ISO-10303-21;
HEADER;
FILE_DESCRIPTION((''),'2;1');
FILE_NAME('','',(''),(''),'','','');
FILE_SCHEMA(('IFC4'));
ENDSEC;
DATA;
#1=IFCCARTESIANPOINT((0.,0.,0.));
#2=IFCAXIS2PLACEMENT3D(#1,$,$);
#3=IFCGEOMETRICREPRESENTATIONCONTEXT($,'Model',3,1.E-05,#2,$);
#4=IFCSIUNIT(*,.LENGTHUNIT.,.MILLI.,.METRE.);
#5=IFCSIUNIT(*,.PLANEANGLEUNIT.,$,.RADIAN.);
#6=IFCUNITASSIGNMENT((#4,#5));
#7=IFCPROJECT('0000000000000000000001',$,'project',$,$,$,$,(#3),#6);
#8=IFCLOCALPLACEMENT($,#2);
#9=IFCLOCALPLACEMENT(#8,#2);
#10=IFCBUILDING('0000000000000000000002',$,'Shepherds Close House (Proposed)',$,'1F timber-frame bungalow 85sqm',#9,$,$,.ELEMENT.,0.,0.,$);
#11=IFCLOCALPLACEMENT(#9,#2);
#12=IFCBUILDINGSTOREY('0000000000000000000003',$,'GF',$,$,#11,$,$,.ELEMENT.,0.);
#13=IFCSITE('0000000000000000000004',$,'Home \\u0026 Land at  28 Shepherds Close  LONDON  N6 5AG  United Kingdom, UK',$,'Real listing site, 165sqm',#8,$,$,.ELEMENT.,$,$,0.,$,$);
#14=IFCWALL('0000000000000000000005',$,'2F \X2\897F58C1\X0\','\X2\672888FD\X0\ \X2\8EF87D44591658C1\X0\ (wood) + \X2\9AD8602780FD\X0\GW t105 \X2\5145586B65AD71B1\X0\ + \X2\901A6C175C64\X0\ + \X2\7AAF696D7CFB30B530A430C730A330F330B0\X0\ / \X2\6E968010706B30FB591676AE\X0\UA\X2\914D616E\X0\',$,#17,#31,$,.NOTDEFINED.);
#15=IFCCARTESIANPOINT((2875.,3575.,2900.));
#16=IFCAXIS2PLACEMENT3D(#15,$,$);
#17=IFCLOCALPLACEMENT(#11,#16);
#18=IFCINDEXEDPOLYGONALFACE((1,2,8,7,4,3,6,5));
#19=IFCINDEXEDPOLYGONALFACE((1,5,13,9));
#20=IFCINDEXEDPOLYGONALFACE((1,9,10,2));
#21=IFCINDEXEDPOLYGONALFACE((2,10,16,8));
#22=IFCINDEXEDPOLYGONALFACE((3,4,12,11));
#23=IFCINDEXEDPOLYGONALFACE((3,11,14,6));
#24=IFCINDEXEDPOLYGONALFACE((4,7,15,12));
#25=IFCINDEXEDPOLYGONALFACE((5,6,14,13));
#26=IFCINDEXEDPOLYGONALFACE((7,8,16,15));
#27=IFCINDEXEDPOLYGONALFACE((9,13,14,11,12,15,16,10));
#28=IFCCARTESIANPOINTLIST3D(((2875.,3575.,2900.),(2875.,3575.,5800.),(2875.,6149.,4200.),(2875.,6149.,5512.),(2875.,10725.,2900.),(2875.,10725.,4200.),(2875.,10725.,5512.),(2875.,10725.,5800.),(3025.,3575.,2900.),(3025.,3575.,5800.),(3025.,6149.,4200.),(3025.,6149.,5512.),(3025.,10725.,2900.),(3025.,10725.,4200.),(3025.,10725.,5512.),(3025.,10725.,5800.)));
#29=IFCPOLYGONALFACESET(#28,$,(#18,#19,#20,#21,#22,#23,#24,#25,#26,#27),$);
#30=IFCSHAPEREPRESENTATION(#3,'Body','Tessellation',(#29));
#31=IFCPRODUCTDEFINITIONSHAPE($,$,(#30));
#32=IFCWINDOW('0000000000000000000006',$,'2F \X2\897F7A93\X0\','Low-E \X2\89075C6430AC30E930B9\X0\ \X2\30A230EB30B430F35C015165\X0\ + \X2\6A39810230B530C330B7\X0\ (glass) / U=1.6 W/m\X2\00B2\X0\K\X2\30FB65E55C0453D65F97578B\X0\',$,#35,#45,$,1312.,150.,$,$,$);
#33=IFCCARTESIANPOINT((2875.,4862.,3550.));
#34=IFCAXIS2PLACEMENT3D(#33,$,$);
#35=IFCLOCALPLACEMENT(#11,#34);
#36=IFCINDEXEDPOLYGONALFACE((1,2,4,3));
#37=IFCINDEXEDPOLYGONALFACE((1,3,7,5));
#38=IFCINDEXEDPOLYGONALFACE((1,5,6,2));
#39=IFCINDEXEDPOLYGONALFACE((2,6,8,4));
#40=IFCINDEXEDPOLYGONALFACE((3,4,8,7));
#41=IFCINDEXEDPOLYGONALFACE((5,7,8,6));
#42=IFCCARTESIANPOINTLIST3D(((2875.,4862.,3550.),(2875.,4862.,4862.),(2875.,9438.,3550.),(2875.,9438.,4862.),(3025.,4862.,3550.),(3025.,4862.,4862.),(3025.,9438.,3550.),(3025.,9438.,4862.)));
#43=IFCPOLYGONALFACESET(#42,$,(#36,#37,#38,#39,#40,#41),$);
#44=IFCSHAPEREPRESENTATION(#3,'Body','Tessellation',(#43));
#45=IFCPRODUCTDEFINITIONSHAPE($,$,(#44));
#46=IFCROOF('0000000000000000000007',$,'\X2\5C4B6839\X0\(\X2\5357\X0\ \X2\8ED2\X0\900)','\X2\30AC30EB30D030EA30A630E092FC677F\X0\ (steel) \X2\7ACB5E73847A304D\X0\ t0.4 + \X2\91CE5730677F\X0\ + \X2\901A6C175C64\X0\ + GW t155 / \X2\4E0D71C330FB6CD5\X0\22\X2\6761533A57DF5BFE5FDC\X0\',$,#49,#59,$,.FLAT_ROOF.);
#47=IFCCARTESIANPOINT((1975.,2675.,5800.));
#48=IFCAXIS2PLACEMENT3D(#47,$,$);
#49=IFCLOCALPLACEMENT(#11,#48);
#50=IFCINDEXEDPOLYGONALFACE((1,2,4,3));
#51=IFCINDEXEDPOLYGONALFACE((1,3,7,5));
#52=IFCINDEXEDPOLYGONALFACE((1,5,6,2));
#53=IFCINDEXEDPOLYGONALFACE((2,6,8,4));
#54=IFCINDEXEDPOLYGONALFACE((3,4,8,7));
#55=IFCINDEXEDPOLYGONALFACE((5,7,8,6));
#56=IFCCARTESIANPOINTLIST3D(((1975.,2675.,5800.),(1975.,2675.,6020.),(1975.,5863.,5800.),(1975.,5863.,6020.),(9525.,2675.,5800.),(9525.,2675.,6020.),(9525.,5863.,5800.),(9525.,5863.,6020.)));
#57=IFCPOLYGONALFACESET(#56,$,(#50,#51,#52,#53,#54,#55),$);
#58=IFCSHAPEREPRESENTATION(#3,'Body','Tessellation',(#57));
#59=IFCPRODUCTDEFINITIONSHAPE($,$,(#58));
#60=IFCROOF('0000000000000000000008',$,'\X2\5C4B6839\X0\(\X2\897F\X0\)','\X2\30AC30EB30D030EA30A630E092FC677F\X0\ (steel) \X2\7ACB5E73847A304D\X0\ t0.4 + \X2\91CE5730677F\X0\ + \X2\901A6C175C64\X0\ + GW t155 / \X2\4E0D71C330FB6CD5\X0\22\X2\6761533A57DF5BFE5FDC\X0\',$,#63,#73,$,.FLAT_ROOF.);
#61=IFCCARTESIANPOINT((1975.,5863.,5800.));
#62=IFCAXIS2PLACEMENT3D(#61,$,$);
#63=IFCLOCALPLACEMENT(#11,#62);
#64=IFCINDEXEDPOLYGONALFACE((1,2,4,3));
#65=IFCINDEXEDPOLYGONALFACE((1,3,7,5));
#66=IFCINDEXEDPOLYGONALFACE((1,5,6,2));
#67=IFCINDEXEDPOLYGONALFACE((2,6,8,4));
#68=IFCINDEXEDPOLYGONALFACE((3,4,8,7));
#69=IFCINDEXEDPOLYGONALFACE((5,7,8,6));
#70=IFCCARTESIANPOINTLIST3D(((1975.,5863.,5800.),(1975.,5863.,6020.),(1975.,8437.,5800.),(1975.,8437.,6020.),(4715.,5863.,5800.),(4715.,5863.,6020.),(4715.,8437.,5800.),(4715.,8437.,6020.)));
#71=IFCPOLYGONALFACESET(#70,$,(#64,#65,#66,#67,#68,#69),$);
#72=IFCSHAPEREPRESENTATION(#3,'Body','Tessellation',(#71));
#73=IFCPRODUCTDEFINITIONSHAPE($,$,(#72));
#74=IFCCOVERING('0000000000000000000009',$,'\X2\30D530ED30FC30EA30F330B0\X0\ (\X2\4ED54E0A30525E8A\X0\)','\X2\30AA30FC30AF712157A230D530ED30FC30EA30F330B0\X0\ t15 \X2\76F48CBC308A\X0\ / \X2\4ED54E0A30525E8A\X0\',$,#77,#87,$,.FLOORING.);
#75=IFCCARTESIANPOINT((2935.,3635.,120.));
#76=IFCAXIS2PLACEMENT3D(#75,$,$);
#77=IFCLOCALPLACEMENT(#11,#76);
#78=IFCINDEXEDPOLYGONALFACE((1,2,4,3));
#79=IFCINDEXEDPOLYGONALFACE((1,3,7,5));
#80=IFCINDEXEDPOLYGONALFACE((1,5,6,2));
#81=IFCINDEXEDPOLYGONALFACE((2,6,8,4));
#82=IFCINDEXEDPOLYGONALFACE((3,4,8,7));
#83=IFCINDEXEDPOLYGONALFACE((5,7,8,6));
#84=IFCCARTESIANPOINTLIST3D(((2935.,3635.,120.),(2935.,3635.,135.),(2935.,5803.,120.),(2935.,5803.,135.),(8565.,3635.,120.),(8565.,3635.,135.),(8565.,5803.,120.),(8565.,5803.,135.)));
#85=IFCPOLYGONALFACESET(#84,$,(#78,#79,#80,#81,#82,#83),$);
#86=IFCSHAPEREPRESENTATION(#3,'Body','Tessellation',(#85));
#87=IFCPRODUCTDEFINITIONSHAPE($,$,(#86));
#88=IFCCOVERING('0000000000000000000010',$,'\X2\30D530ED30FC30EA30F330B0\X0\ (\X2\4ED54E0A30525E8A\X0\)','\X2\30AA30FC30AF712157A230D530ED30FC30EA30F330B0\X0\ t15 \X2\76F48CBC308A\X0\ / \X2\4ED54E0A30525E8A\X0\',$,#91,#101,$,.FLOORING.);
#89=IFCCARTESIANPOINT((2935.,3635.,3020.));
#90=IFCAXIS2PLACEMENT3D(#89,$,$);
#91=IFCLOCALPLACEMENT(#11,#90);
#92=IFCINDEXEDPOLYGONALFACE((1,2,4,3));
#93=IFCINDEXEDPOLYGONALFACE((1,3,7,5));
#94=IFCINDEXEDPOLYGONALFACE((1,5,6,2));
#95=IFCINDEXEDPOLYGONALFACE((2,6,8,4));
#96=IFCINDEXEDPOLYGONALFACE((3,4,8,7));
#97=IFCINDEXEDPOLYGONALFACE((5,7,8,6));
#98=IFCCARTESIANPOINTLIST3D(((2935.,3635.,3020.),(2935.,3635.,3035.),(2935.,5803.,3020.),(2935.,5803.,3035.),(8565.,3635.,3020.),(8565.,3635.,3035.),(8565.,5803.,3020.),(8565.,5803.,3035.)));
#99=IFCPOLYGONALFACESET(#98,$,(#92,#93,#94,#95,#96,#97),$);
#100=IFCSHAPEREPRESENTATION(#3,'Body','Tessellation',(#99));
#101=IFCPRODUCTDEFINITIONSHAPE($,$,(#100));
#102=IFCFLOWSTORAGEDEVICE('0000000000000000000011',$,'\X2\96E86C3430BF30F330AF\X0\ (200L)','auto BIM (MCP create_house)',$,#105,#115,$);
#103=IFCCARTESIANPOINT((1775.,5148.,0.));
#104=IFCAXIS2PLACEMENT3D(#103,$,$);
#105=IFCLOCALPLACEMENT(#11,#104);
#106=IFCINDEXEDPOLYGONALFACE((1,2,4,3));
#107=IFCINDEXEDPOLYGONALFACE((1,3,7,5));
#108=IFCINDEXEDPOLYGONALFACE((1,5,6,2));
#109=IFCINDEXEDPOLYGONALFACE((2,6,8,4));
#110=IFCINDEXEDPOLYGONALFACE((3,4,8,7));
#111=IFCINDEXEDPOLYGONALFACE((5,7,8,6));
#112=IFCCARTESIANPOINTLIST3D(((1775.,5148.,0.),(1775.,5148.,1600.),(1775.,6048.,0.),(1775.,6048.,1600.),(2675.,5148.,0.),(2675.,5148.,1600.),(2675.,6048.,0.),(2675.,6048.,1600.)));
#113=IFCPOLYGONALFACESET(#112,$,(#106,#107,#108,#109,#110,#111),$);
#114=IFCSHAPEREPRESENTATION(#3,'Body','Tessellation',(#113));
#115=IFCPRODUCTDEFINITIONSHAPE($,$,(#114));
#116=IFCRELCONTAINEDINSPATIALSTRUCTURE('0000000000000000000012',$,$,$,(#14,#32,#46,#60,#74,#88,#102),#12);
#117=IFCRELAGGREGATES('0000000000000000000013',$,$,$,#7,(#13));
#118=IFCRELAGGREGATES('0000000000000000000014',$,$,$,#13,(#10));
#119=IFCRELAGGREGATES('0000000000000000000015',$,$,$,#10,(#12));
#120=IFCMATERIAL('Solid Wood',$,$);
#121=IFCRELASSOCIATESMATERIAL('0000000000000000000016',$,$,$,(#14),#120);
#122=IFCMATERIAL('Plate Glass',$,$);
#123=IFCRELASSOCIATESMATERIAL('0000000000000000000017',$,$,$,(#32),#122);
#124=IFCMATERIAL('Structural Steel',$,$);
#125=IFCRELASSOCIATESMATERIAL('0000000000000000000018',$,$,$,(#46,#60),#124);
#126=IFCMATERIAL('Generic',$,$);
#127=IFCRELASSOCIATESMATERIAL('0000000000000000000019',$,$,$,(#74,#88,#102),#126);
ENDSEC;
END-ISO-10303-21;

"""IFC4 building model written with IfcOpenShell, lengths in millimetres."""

from ifc_helpers import new_model, si_unit, frame, frame_2d, origin, place, context, project, spatial, rectangle, extrude, material, element, fill, save


model = new_model("IFC4")

# Units and contexts
model_context = context("Model", 3, precision=1e-05, world=origin())
ifc_project = project(units=[si_unit("LENGTHUNIT", "METRE", prefix="MILLI"), si_unit("PLANEANGLEUNIT", "RADIAN")], contexts=[model_context])

# Site, building, storey
site_placement = place(None, origin())
site = spatial("IfcSite", under=ifc_project, at=site_placement, Name="Home \\u0026 Land at  28 Shepherds Close  LONDON  N6 5AG  United Kingdom, UK", ObjectType="Real listing site, 165sqm", CompositionType="ELEMENT", RefElevation=0.0)
building_placement = place(site_placement, origin())
building = spatial("IfcBuilding", under=site, at=building_placement, Name="Shepherds Close House (Proposed)", ObjectType="1F timber-frame bungalow 85sqm", CompositionType="ELEMENT", ElevationOfRefHeight=0.0, ElevationOfTerrain=0.0)
storey_placement = place(building_placement, origin())
storey = spatial("IfcBuildingStorey", under=building, at=storey_placement, Name="GF", CompositionType="ELEMENT", Elevation=0.0)

# Shared definitions
ifc_material_1 = material(Name="Solid Wood")
ifc_material_2 = material(Name="Generic")

# Shared definitions
ifc_material_3 = material(Name="Plate Glass")

# Wall, opening, window
wall_1_placement = place(storey_placement, frame((2875.0, 3575.0, 2900.0)))
wall_1 = element("IfcWall", 1, at=wall_1_placement, inside=storey, material=ifc_material_1, Name="2F 西壁", Description="木製 軸組外壁 (wood) + 高性能GW t105 充填断熱 + 通気層 + 窯業系サイディング / 準耐火・外皮UA配慮", PredefinedType="NOTDEFINED", context=model_context, shape_type="SweptSolid", body=[
    extrude(rectangle(XDim=150.0, YDim=7150.0, at=frame_2d((75.0, 3575.0))), frame((2875.0, 3575.0, 2900.0)), (0.0, 0.0, 1.0), 2900.0),
])
opening_1_placement = place(storey_placement, frame((2875.0, 4862.0, 3550.0)))
opening_1 = element("IfcOpeningElement", 2, at=opening_1_placement, cuts=wall_1, PredefinedType="NOTDEFINED", context=model_context, shape_type="SweptSolid", body=[
    extrude(rectangle(XDim=150.0, YDim=4576.0, at=frame_2d((75.0, 2288.0))), frame((2875.0, 4862.0, 3550.0)), (0.0, 0.0, 1.0), 1312.0),
])
window_1_placement = place(storey_placement, frame((2875.0, 4862.0, 3550.0)))
window_1 = element("IfcWindow", 3, at=window_1_placement, inside=storey, material=ifc_material_3, Name="2F 西窓", Description="Low-E 複層ガラス アルゴン封入 + 樹脂サッシ (glass) / U=1.6 W/m²K・日射取得型", OverallHeight=1312.0, OverallWidth=150.0, context=model_context, shape_type="SweptSolid", body=[
    extrude(rectangle(XDim=150.0, YDim=4576.0, at=frame_2d((75.0, 2288.0))), frame((2875.0, 4862.0, 3550.0)), (0.0, 0.0, 1.0), 1312.0),
])
fill(opening_1, window_1)

# Roofs
ifc_material_4 = material(Name="Structural Steel")
roof_1_placement = place(storey_placement, frame((1975.0, 2675.0, 5800.0)))
element("IfcRoof", 4, at=roof_1_placement, inside=storey, material=ifc_material_4, Name="屋根(南 軒900)", Description="ガルバリウム鋼板 (steel) 立平葺き t0.4 + 野地板 + 通気層 + GW t155 / 不燃・法22条区域対応", PredefinedType="FLAT_ROOF", context=model_context, shape_type="SweptSolid", body=[
    extrude(rectangle(XDim=7550.0, YDim=3188.0, at=frame_2d((3775.0, 1594.0))), frame((1975.0, 2675.0, 5800.0)), (0.0, 0.0, 1.0), 220.0),
])
roof_2_placement = place(storey_placement, frame((1975.0, 5863.0, 5800.0)))
element("IfcRoof", 5, at=roof_2_placement, inside=storey, material=ifc_material_4, Name="屋根(西)", Description="ガルバリウム鋼板 (steel) 立平葺き t0.4 + 野地板 + 通気層 + GW t155 / 不燃・法22条区域対応", PredefinedType="FLAT_ROOF", context=model_context, shape_type="SweptSolid", body=[
    extrude(rectangle(XDim=2740.0, YDim=2574.0, at=frame_2d((1370.0, 1287.0))), frame((1975.0, 5863.0, 5800.0)), (0.0, 0.0, 1.0), 220.0),
])

# Coverings
covering_1_placement = place(storey_placement, frame((2935.0, 3635.0, 120.0)))
element("IfcCovering", 6, at=covering_1_placement, inside=storey, material=ifc_material_2, Name="フローリング (仕上げ床)", Description="オーク無垢フローリング t15 直貼り / 仕上げ床", PredefinedType="FLOORING", context=model_context, shape_type="SweptSolid", body=[
    extrude(rectangle(XDim=5630.0, YDim=2168.0, at=frame_2d((2815.0, 1084.0))), frame((2935.0, 3635.0, 120.0)), (0.0, 0.0, 1.0), 15.0),
])
covering_2_placement = place(storey_placement, frame((2935.0, 3635.0, 3020.0)))
element("IfcCovering", 7, at=covering_2_placement, inside=storey, material=ifc_material_2, Name="フローリング (仕上げ床)", Description="オーク無垢フローリング t15 直貼り / 仕上げ床", PredefinedType="FLOORING", context=model_context, shape_type="SweptSolid", body=[
    extrude(rectangle(XDim=5630.0, YDim=2168.0, at=frame_2d((2815.0, 1084.0))), frame((2935.0, 3635.0, 3020.0)), (0.0, 0.0, 1.0), 15.0),
])

# Flow storage device
flow_storage_device_placement = place(storey_placement, frame((1775.0, 5148.0, 0.0)))
element("IfcFlowStorageDevice", 8, at=flow_storage_device_placement, inside=storey, material=ifc_material_2, Name="雨水タンク (200L)", Description="auto BIM (MCP create_house)", context=model_context, shape_type="SweptSolid", body=[
    extrude(rectangle(XDim=900.0, YDim=900.0, at=frame_2d((450.0, 450.0))), frame((1775.0, 5148.0, 0.0)), (0.0, 0.0, 1.0), 1600.0),
])

save(model, "model.ifc")
